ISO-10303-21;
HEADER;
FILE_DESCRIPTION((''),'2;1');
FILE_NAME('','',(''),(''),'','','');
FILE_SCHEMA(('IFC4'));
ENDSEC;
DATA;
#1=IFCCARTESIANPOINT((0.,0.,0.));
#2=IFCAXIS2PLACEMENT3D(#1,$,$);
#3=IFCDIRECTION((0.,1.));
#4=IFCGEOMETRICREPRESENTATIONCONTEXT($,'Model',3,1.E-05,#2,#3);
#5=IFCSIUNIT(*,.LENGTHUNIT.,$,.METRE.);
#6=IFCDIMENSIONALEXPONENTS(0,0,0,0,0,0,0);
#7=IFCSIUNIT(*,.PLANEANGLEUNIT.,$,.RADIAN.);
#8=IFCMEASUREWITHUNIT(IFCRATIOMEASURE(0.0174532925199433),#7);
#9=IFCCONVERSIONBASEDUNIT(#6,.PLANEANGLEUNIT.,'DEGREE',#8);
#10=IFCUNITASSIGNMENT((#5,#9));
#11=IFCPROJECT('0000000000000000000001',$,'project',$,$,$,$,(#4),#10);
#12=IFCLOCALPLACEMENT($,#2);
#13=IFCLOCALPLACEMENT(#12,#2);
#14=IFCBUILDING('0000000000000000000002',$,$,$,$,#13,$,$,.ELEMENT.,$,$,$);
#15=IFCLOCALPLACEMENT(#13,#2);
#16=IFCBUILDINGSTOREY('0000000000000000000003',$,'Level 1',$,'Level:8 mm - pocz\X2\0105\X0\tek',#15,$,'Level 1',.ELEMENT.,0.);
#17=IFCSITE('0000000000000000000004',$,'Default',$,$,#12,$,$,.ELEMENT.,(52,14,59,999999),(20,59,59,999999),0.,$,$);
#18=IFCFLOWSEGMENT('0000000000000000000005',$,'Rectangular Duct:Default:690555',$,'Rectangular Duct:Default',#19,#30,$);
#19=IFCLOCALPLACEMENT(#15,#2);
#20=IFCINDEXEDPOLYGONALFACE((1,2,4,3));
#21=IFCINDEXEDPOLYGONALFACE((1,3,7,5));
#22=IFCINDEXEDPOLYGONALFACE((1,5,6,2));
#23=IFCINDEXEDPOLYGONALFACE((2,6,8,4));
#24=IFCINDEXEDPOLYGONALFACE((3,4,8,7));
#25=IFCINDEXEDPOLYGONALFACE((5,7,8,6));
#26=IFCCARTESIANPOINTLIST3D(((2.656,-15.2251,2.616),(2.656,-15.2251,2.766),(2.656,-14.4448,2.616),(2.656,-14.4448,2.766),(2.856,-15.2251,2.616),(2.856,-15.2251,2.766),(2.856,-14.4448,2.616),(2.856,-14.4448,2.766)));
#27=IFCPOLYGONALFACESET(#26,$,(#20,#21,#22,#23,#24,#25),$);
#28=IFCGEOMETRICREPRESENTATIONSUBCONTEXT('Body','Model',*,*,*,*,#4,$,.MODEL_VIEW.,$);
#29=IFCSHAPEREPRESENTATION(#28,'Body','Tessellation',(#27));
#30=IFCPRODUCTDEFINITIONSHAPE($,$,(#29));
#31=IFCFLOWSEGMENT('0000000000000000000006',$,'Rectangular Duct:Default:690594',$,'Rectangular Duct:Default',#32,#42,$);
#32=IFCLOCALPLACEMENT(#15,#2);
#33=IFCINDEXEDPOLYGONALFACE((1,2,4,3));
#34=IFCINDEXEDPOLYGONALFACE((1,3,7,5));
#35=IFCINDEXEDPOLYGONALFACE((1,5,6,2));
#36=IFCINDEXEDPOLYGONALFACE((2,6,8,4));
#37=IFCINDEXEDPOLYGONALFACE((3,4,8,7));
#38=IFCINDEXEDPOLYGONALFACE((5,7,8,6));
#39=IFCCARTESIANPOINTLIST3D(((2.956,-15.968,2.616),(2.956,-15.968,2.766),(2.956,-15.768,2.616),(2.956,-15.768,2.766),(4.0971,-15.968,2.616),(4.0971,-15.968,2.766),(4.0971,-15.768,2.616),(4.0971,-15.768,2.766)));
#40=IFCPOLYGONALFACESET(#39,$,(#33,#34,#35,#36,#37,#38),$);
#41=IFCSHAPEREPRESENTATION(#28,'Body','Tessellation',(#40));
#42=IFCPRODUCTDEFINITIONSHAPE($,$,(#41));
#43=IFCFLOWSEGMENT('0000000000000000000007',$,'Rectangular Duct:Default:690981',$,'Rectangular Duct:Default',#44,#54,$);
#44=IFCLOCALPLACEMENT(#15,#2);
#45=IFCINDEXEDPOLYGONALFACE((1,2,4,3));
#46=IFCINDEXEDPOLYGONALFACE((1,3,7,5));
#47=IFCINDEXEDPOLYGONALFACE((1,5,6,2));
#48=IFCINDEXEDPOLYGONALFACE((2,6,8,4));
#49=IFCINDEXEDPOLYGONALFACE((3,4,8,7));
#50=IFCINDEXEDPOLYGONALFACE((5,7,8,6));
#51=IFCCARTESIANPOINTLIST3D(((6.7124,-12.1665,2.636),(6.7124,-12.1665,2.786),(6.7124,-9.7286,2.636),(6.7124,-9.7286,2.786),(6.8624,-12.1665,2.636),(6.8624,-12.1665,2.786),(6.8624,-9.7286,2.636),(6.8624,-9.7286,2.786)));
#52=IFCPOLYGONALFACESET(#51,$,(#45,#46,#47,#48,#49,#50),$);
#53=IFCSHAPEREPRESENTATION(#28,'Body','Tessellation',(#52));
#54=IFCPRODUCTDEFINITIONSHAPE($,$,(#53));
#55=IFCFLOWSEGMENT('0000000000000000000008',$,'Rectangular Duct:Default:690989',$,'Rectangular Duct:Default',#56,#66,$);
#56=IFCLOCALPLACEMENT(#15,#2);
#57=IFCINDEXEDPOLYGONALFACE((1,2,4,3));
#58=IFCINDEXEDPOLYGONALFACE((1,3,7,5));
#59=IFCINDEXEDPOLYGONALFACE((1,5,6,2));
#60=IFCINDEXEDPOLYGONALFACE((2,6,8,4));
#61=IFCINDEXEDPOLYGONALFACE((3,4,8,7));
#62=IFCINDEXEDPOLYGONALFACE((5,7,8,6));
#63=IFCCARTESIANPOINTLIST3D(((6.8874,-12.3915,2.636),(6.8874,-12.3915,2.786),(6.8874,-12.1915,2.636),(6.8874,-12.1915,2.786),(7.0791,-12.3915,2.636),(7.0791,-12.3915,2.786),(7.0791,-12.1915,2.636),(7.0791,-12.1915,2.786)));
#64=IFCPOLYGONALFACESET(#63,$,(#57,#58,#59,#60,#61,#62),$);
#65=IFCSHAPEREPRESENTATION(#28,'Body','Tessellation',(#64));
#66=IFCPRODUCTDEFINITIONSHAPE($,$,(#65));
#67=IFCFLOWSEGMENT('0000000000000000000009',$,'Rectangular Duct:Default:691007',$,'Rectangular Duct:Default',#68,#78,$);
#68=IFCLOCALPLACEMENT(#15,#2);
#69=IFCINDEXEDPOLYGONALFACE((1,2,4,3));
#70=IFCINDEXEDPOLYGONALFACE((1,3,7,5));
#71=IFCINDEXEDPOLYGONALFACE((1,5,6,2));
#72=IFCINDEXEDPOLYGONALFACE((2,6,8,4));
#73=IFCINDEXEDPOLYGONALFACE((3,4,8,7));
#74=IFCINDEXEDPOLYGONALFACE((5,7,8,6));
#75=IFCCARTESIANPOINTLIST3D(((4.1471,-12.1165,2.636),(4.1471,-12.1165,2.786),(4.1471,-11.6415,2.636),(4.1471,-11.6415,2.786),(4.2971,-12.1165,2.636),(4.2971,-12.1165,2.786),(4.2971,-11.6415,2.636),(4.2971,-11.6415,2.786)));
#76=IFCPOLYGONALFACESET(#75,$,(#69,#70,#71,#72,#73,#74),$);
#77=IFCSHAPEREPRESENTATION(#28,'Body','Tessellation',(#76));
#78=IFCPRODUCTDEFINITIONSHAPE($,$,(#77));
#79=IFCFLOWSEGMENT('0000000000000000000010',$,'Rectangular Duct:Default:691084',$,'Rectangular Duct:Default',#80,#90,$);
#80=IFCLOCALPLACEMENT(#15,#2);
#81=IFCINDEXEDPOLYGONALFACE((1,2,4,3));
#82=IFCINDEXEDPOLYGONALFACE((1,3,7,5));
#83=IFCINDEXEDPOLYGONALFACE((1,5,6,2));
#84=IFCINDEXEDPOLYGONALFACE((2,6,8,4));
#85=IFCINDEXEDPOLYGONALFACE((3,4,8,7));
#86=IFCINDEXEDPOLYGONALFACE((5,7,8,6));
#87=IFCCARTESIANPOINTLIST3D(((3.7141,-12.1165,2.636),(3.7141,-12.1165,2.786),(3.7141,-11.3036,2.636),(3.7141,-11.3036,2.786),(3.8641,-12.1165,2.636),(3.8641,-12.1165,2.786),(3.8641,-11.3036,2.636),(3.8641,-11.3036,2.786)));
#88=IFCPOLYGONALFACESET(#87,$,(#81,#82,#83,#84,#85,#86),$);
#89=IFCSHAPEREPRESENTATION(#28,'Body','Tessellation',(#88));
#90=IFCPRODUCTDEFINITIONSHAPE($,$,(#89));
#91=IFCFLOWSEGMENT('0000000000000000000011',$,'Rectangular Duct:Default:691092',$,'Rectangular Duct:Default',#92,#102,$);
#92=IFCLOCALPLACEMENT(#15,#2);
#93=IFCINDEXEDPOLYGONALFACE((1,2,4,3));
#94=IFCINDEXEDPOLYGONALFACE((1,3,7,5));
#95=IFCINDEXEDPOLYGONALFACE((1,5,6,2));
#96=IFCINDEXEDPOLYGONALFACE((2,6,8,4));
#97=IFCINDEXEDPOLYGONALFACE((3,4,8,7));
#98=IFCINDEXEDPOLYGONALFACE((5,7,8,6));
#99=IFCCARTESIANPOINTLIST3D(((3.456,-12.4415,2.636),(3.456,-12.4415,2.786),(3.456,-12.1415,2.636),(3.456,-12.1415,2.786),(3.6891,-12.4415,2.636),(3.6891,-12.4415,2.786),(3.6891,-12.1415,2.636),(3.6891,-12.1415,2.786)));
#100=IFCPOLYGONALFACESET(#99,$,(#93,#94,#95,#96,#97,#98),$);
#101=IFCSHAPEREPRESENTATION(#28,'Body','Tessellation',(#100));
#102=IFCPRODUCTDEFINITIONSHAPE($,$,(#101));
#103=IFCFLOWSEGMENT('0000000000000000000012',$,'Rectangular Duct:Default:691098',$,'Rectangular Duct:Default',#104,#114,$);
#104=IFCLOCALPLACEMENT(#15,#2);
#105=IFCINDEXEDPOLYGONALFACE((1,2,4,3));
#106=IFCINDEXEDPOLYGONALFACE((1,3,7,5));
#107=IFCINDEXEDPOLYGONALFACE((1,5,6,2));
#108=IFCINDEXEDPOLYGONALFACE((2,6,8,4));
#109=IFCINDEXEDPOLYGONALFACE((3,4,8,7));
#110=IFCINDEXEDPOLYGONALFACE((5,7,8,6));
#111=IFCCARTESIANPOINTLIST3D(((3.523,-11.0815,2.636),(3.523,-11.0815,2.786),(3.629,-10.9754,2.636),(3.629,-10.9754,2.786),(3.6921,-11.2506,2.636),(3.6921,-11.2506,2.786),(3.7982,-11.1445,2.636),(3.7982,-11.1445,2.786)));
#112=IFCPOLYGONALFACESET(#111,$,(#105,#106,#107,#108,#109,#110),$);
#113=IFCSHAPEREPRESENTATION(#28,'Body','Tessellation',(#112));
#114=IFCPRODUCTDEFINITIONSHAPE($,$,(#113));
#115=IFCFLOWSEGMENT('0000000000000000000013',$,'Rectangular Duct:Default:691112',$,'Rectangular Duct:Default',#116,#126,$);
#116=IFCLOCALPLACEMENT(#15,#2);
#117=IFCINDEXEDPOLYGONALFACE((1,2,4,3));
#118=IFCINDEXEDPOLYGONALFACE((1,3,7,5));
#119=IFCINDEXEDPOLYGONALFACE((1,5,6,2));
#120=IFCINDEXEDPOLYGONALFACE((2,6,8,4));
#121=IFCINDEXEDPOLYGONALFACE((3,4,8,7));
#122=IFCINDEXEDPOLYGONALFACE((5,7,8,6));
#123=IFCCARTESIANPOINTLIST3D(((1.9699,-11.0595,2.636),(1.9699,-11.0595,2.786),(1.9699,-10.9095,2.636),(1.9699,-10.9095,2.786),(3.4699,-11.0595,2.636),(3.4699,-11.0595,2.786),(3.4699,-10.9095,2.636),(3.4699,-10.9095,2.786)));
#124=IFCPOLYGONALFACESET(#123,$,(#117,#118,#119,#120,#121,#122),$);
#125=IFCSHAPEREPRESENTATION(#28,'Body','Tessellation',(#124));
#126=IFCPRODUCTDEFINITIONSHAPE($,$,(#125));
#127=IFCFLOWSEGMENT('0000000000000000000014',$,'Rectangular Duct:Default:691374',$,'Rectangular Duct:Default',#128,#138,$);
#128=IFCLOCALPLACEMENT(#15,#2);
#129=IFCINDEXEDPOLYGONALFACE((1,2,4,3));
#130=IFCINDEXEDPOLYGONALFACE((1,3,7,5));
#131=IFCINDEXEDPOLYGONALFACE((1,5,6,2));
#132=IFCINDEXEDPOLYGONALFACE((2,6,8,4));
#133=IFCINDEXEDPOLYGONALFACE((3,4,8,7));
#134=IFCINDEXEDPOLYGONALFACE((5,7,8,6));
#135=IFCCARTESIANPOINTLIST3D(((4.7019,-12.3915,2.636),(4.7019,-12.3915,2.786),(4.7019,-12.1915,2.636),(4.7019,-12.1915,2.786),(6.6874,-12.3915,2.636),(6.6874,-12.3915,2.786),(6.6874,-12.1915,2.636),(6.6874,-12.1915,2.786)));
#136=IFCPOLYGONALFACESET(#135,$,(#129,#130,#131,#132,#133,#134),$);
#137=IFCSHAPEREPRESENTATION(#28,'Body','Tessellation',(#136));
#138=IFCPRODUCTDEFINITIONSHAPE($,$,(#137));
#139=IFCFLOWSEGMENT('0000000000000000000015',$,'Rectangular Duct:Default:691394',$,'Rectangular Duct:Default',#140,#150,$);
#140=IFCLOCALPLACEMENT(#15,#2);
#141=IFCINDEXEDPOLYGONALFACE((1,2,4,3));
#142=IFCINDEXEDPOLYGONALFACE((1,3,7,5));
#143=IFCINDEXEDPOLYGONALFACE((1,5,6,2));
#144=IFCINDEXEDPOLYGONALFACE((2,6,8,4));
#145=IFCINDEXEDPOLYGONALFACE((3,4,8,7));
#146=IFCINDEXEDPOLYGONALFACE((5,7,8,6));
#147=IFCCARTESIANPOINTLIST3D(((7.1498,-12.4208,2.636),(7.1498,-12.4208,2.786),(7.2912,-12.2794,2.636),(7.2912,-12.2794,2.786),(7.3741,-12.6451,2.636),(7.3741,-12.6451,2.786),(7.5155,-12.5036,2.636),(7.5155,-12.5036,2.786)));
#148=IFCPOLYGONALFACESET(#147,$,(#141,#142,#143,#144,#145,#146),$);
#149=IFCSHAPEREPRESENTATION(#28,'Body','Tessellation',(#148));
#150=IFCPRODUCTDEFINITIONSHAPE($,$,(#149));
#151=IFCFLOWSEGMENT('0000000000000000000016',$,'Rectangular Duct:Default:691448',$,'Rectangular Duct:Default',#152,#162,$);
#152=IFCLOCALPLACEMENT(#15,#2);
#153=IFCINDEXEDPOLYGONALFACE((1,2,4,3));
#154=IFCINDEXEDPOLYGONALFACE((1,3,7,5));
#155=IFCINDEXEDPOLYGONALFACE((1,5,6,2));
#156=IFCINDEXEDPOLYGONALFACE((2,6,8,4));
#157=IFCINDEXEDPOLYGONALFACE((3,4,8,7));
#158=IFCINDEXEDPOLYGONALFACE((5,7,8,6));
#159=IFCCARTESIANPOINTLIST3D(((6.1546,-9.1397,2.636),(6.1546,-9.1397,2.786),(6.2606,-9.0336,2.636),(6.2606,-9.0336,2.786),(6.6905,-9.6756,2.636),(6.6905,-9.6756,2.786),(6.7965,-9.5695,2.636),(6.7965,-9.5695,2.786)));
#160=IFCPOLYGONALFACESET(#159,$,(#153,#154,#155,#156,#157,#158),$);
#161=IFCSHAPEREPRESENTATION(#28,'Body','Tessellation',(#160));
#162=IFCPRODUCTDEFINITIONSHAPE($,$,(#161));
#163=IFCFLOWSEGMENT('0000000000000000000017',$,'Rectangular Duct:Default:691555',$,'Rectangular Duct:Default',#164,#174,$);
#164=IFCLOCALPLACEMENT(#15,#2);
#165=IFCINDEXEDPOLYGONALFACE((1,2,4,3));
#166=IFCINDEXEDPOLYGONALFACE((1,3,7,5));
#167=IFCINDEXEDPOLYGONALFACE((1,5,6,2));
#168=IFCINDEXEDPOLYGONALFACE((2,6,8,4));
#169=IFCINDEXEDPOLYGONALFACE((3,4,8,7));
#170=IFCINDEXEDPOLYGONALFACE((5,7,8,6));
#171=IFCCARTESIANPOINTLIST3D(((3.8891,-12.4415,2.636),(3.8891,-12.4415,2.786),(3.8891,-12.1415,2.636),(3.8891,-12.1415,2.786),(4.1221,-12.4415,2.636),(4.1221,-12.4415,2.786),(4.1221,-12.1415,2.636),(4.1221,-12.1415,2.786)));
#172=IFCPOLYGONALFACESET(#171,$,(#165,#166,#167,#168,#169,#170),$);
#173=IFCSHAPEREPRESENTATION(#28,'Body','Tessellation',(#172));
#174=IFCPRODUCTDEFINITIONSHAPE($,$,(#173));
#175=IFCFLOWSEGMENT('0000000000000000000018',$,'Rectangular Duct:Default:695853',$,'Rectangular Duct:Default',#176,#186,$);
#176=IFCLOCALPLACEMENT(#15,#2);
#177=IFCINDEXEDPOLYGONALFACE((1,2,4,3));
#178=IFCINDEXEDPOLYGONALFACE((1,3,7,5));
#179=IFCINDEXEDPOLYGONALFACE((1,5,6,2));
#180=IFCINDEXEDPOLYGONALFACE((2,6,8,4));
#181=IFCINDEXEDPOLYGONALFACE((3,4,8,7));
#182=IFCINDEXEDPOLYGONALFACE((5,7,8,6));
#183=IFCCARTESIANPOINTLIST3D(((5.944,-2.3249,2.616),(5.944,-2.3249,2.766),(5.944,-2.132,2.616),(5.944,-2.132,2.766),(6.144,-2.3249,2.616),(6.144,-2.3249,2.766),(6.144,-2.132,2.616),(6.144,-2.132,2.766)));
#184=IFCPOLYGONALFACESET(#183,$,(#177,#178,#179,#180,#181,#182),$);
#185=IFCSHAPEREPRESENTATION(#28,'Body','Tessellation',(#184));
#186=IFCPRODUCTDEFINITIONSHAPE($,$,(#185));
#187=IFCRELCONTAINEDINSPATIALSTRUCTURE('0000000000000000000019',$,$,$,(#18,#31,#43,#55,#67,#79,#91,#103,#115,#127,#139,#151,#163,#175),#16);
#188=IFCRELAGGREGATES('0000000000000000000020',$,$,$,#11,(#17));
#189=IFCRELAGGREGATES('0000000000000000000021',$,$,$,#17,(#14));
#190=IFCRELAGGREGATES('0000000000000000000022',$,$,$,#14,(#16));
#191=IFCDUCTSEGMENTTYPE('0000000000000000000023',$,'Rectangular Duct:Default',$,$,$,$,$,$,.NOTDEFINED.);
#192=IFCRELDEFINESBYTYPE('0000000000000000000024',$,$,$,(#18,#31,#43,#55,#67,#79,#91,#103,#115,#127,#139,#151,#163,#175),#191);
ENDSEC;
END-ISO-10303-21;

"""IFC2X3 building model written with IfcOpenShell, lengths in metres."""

from ifc_helpers import new_model, entity, si_unit, converted_unit, direction, frame, frame_2d, origin, origin_2d_with_axis, place, context, subcontext, project, spatial, rectangle, extrude, type_object, element, save


model = new_model("IFC2X3")

# Units and contexts
model_context = context("Model", 3, precision=1e-05, world=origin(), true_north=direction((0.0, 1.0)))
body_context = subcontext(model_context, "Body", "Model", "MODEL_VIEW")
ifc_project = project(units=[si_unit("LENGTHUNIT", "METRE"), converted_unit("PLANEANGLEUNIT", "DEGREE", entity("IfcRatioMeasure", 0.0174532925199433), si_unit("PLANEANGLEUNIT", "RADIAN"), dimensions=[0, 0, 0, 0, 0, 0, 0])], contexts=[model_context])

# Site, building, storey
site_placement = place(None, origin())
site = spatial("IfcSite", under=ifc_project, at=site_placement, Name="Default", CompositionType="ELEMENT", RefLatitude=(52, 14, 59, 999999), RefLongitude=(20, 59, 59, 999999), RefElevation=0.0)
building_placement = place(site_placement, origin())
building = spatial("IfcBuilding", under=site, at=building_placement, CompositionType="ELEMENT")
storey_placement = place(building_placement, origin())
storey = spatial("IfcBuildingStorey", under=building, at=storey_placement, Name="Level 1", ObjectType="Level:8 mm - początek", LongName="Level 1", CompositionType="ELEMENT", Elevation=0.0)

# Flow segments
duct_segment_type_1 = type_object("IfcDuctSegmentType", Name="Rectangular Duct:Default", PredefinedType="NOTDEFINED")
flow_segment_1_placement = place(storey_placement, origin())
element("IfcFlowSegment", 1, at=flow_segment_1_placement, inside=storey, type_object=duct_segment_type_1, Name="Rectangular Duct:Default:690555", ObjectType="Rectangular Duct:Default", context=body_context, shape_type="SweptSolid", body=[
    extrude(rectangle(XDim=0.7804, YDim=0.2, at=frame_2d((0.0, 0.0), x_axis=(1.0, 0.0))), frame((2.756, -14.835, 2.616), z_axis=(0.0, 0.0, 1.0), x_axis=(0.0, -1.0, 0.0)), (0.0, 0.0, 1.0), 0.15),
])
flow_segment_2_placement = place(storey_placement, origin())
element("IfcFlowSegment", 2, at=flow_segment_2_placement, inside=storey, type_object=duct_segment_type_1, Name="Rectangular Duct:Default:690594", ObjectType="Rectangular Duct:Default", context=body_context, shape_type="SweptSolid", body=[
    extrude(rectangle(XDim=1.1411, YDim=0.2, at=frame_2d((0.0, 0.0), x_axis=(1.0, 0.0))), frame((3.5266, -15.868, 2.616)), (0.0, 0.0, 1.0), 0.15),
])
flow_segment_3_placement = place(storey_placement, origin())
element("IfcFlowSegment", 3, at=flow_segment_3_placement, inside=storey, type_object=duct_segment_type_1, Name="Rectangular Duct:Default:690981", ObjectType="Rectangular Duct:Default", context=body_context, shape_type="SweptSolid", body=[
    extrude(rectangle(XDim=2.4379, YDim=0.15, at=origin_2d_with_axis()), frame((6.7874, -10.9476, 2.636), z_axis=(0.0, 0.0, 1.0), x_axis=(0.0, 1.0, 0.0)), (0.0, 0.0, 1.0), 0.15),
])
flow_segment_4_placement = place(storey_placement, origin())
element("IfcFlowSegment", 4, at=flow_segment_4_placement, inside=storey, type_object=duct_segment_type_1, Name="Rectangular Duct:Default:690989", ObjectType="Rectangular Duct:Default", context=body_context, shape_type="SweptSolid", body=[
    extrude(rectangle(XDim=0.1917, YDim=0.2, at=frame_2d((0.0, 0.0), x_axis=(1.0, 0.0))), frame((6.9833, -12.2915, 2.636)), (0.0, 0.0, 1.0), 0.15),
])
flow_segment_5_placement = place(storey_placement, origin())
element("IfcFlowSegment", 5, at=flow_segment_5_placement, inside=storey, type_object=duct_segment_type_1, Name="Rectangular Duct:Default:691007", ObjectType="Rectangular Duct:Default", context=body_context, shape_type="SweptSolid", body=[
    extrude(rectangle(XDim=0.475, YDim=0.15, at=frame_2d((0.0, 0.0), x_axis=(1.0, 0.0))), frame((4.2221, -11.879, 2.636), z_axis=(0.0, 0.0, 1.0), x_axis=(0.0, -1.0, 0.0)), (0.0, 0.0, 1.0), 0.15),
])
flow_segment_6_placement = place(storey_placement, origin())
element("IfcFlowSegment", 6, at=flow_segment_6_placement, inside=storey, type_object=duct_segment_type_1, Name="Rectangular Duct:Default:691084", ObjectType="Rectangular Duct:Default", context=body_context, shape_type="SweptSolid", body=[
    extrude(rectangle(XDim=0.8129, YDim=0.15, at=frame_2d((0.0, 0.0), x_axis=(1.0, 0.0))), frame((3.7891, -11.7101, 2.636), z_axis=(0.0, 0.0, 1.0), x_axis=(0.0, 1.0, 0.0)), (0.0, 0.0, 1.0), 0.15),
])
flow_segment_7_placement = place(storey_placement, origin())
element("IfcFlowSegment", 7, at=flow_segment_7_placement, inside=storey, type_object=duct_segment_type_1, Name="Rectangular Duct:Default:691092", ObjectType="Rectangular Duct:Default", context=body_context, shape_type="SweptSolid", body=[
    extrude(rectangle(XDim=0.2331, YDim=0.3, at=frame_2d((0.0, 0.0), x_axis=(1.0, 0.0))), frame((3.5725, -12.2915, 2.636)), (0.0, 0.0, 1.0), 0.15),
])
flow_segment_8_placement = place(storey_placement, origin())
element("IfcFlowSegment", 8, at=flow_segment_8_placement, inside=storey, type_object=duct_segment_type_1, Name="Rectangular Duct:Default:691098", ObjectType="Rectangular Duct:Default", context=body_context, shape_type="SweptSolid", body=[
    extrude(rectangle(XDim=0.2392, YDim=0.15, at=origin_2d_with_axis()), frame((3.6606, -11.113, 2.636), z_axis=(0.0, 0.0, 1.0), x_axis=(-0.707107, 0.707107, 0.0)), (0.0, 0.0, 1.0), 0.15),
])
flow_segment_9_placement = place(storey_placement, origin())
element("IfcFlowSegment", 9, at=flow_segment_9_placement, inside=storey, type_object=duct_segment_type_1, Name="Rectangular Duct:Default:691112", ObjectType="Rectangular Duct:Default", context=body_context, shape_type="SweptSolid", body=[
    extrude(rectangle(XDim=1.5, YDim=0.15, at=frame_2d((0.0, 0.0), x_axis=(1.0, 0.0))), frame((2.7199, -10.9845, 2.636), z_axis=(0.0, 0.0, 1.0), x_axis=(-1.0, 0.0, 0.0)), (0.0, 0.0, 1.0), 0.15),
])
flow_segment_10_placement = place(storey_placement, origin())
element("IfcFlowSegment", 10, at=flow_segment_10_placement, inside=storey, type_object=duct_segment_type_1, Name="Rectangular Duct:Default:691374", ObjectType="Rectangular Duct:Default", context=body_context, shape_type="SweptSolid", body=[
    extrude(rectangle(XDim=1.9855, YDim=0.2, at=frame_2d((0.0, 0.0), x_axis=(1.0, 0.0))), frame((5.6947, -12.2915, 2.636), z_axis=(0.0, 0.0, 1.0), x_axis=(-1.0, 0.0, 0.0)), (0.0, 0.0, 1.0), 0.15),
])
flow_segment_11_placement = place(storey_placement, origin())
element("IfcFlowSegment", 11, at=flow_segment_11_placement, inside=storey, type_object=duct_segment_type_1, Name="Rectangular Duct:Default:691394", ObjectType="Rectangular Duct:Default", context=body_context, shape_type="SweptSolid", body=[
    extrude(rectangle(XDim=0.3172, YDim=0.2, at=frame_2d((0.0, 0.0), x_axis=(1.0, 0.0))), frame((7.3326, -12.4622, 2.636), z_axis=(0.0, 0.0, 1.0), x_axis=(0.707107, -0.707107, 0.0)), (0.0, 0.0, 1.0), 0.15),
])
flow_segment_12_placement = place(storey_placement, origin())
element("IfcFlowSegment", 12, at=flow_segment_12_placement, inside=storey, type_object=duct_segment_type_1, Name="Rectangular Duct:Default:691448", ObjectType="Rectangular Duct:Default", context=body_context, shape_type="SweptSolid", body=[
    extrude(rectangle(XDim=0.7579, YDim=0.15, at=frame_2d((0.0, 0.0), x_axis=(1.0, 0.0))), frame((6.4756, -9.3546, 2.636), z_axis=(0.0, 0.0, 1.0), x_axis=(-0.707107, 0.707107, 0.0)), (0.0, 0.0, 1.0), 0.15),
])
flow_segment_13_placement = place(storey_placement, origin())
element("IfcFlowSegment", 13, at=flow_segment_13_placement, inside=storey, type_object=duct_segment_type_1, Name="Rectangular Duct:Default:691555", ObjectType="Rectangular Duct:Default", context=body_context, shape_type="SweptSolid", body=[
    extrude(rectangle(XDim=0.2331, YDim=0.3, at=frame_2d((0.0, 0.0), x_axis=(1.0, 0.0))), frame((4.0056, -12.2915, 2.636)), (0.0, 0.0, 1.0), 0.15),
])
flow_segment_14_placement = place(storey_placement, origin())
element("IfcFlowSegment", 14, at=flow_segment_14_placement, inside=storey, type_object=duct_segment_type_1, Name="Rectangular Duct:Default:695853", ObjectType="Rectangular Duct:Default", context=body_context, shape_type="SweptSolid", body=[
    extrude(rectangle(XDim=0.1929, YDim=0.2, at=origin_2d_with_axis()), frame((6.044, -2.2284, 2.616), z_axis=(0.0, 0.0, 1.0), x_axis=(0.0, 1.0, 0.0)), (0.0, 0.0, 1.0), 0.15),
])

save(model, "model.ifc")
